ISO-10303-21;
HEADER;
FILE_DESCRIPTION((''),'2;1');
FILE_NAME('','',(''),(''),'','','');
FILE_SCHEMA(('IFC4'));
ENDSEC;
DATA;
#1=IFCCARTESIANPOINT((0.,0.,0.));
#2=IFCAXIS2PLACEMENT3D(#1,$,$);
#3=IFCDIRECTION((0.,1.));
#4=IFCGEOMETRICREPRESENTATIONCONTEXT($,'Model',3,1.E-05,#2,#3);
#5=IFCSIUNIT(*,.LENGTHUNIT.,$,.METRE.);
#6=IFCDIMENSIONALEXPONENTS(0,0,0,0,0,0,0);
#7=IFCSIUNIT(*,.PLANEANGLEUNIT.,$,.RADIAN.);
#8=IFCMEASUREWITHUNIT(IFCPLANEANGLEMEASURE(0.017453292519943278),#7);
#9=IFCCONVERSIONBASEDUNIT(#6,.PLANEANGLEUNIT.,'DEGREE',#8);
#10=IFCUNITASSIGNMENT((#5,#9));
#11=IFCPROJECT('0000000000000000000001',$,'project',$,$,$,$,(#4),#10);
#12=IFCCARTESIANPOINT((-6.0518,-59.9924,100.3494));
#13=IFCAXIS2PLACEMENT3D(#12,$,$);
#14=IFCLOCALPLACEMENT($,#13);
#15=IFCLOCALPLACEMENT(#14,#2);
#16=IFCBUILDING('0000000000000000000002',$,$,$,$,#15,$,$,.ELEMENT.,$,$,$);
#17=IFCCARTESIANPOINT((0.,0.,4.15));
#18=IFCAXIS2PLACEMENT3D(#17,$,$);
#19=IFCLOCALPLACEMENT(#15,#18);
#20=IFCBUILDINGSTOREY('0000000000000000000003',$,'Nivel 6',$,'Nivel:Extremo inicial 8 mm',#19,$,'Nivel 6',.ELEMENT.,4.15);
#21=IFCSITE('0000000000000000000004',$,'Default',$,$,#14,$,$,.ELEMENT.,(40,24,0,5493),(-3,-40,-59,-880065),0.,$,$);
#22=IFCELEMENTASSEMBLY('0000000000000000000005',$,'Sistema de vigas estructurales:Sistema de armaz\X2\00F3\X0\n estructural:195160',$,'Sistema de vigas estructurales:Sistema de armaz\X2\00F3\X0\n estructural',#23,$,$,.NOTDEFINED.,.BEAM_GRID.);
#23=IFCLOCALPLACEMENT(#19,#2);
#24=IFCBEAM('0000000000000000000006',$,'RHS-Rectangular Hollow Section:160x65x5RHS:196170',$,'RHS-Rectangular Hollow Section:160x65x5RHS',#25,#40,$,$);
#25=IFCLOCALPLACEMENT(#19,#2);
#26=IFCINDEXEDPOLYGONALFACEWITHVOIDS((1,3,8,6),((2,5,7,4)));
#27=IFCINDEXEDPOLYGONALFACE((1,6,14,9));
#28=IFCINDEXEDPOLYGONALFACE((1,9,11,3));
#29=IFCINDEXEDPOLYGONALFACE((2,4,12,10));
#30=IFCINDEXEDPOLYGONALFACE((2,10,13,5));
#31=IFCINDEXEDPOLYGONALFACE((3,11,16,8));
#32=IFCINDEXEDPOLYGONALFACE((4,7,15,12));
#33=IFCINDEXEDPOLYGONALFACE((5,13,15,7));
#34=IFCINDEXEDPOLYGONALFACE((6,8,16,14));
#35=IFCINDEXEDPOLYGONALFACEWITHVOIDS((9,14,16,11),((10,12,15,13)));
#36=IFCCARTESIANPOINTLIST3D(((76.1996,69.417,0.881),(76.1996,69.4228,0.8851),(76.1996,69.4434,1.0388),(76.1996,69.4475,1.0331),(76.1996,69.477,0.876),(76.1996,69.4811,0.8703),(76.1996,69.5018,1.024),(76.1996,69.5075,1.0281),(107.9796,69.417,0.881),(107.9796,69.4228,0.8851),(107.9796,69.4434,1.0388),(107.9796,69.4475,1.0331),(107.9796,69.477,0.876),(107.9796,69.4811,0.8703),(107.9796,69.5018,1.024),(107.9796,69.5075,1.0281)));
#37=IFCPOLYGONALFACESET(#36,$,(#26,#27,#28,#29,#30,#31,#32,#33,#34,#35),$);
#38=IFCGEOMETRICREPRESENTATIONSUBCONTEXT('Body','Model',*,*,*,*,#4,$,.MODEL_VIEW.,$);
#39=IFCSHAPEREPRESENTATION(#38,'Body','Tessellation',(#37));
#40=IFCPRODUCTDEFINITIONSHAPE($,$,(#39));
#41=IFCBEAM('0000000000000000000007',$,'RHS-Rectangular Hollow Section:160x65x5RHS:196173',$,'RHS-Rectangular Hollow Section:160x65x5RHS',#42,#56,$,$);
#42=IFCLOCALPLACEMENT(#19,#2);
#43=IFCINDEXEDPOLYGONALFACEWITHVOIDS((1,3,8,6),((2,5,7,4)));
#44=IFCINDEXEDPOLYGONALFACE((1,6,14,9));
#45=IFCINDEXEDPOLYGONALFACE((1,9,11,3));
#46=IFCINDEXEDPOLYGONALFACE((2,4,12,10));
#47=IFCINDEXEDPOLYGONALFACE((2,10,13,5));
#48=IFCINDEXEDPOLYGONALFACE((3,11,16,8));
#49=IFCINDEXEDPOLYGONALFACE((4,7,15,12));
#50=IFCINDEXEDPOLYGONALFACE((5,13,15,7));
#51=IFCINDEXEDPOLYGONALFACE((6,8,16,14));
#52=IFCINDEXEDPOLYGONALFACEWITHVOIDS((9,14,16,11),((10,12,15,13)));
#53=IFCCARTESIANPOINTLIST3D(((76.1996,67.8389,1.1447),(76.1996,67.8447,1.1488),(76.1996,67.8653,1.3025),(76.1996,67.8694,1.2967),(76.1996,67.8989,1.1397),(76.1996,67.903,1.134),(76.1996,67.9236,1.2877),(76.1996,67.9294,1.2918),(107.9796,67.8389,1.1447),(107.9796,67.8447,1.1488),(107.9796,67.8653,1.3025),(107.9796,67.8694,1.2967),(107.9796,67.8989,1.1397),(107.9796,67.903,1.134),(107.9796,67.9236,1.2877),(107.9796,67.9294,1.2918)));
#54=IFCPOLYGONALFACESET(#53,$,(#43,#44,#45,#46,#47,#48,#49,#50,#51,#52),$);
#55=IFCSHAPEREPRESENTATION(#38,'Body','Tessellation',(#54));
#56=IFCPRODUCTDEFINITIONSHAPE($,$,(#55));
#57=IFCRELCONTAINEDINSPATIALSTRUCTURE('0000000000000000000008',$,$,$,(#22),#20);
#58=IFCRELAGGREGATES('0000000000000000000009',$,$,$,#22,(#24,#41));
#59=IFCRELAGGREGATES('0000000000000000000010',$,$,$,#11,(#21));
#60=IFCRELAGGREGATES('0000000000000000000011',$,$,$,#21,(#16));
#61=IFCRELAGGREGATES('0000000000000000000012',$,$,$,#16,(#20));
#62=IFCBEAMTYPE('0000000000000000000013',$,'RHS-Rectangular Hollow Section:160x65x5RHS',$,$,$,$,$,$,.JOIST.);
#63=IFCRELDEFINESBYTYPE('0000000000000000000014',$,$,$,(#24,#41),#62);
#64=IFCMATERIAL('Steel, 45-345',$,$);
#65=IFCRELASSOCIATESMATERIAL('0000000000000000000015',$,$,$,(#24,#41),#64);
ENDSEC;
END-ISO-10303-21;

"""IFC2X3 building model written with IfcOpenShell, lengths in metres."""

from ifc_helpers import new_model, entity, si_unit, converted_unit, direction, frame, frame_2d, origin, place, context, subcontext, project, spatial, rectangle, extrude, boolean, material, type_object, element, aggregate, save


model = new_model("IFC2X3")

# Units and contexts
model_context = context("Model", 3, precision=1e-05, world=origin(), true_north=direction((0.0, 1.0)))
body_context = subcontext(model_context, "Body", "Model", "MODEL_VIEW")
ifc_project = project(units=[si_unit("LENGTHUNIT", "METRE"), converted_unit("PLANEANGLEUNIT", "DEGREE", entity("IfcPlaneAngleMeasure", 0.017453292519943278), si_unit("PLANEANGLEUNIT", "RADIAN"), dimensions=[0, 0, 0, 0, 0, 0, 0])], contexts=[model_context])

# Site, building, storey
site_placement = place(None, frame((-6.0518, -59.9924, 100.3494)))
site = spatial("IfcSite", under=ifc_project, at=site_placement, Name="Default", CompositionType="ELEMENT", RefLatitude=(40, 24, 0, 5493), RefLongitude=(-3, -40, -59, -880065), RefElevation=0.0)
building_placement = place(site_placement, origin())
building = spatial("IfcBuilding", under=site, at=building_placement, CompositionType="ELEMENT")
storey_placement = place(building_placement, frame((0.0, 0.0, 4.15)))
storey = spatial("IfcBuildingStorey", under=building, at=storey_placement, Name="Nivel 6", ObjectType="Nivel:Extremo inicial 8 mm", LongName="Nivel 6", CompositionType="ELEMENT", Elevation=4.15)

# Shared definitions
ifc_material_1 = material(Name="Steel, 45-345")

# Element assembly, beams
assembly_placement = place(storey_placement, origin())
assembly = element("IfcElementAssembly", 1, at=assembly_placement, inside=storey, Name="Sistema de vigas estructurales:Sistema de armazón estructural:195160", ObjectType="Sistema de vigas estructurales:Sistema de armazón estructural", AssemblyPlace="NOTDEFINED", PredefinedType="BEAM_GRID")
beam_type_1 = type_object("IfcBeamType", Name="RHS-Rectangular Hollow Section:160x65x5RHS", PredefinedType="JOIST")
beam_1_placement = place(assembly_placement, frame((107.9796, 69.4227, 0.7178), z_axis=(0.0, 0.0, 1.0), x_axis=(-1.0, 0.0, 0.0)))
beam_1 = element("IfcBeam", 2, at=beam_1_placement, type_object=beam_type_1, material=ifc_material_1, Name="RHS-Rectangular Hollow Section:160x65x5RHS:196170", ObjectType="RHS-Rectangular Hollow Section:160x65x5RHS", context=body_context, shape_type="SweptSolid", body=[
    boolean("DIFFERENCE", extrude(rectangle(XDim=0.16, YDim=0.065, at=frame_2d((0.0, 0.0), x_axis=(0.0, 1.0))), frame((0.0, -0.0396, 0.2367), z_axis=(1.0, 0.0, 0.0), x_axis=(0.0, -0.986325, -0.16481)), (0.0, 0.0, 1.0), 31.78), extrude(rectangle(XDim=0.15, YDim=0.055, at=frame_2d((0.0, 0.0), x_axis=(0.0, 1.0))), frame((31.78, -0.0396, 0.2367), z_axis=(-1.0, 0.0, 0.0), x_axis=(0.0, 0.986325, 0.16481)), (0.0, 0.0, 1.0), 31.78)),
])
beam_2_placement = place(assembly_placement, frame((107.9796, 67.8446, 0.9815), z_axis=(0.0, 0.0, 1.0), x_axis=(-1.0, 0.0, 0.0)))
beam_2 = element("IfcBeam", 3, at=beam_2_placement, type_object=beam_type_1, material=ifc_material_1, Name="RHS-Rectangular Hollow Section:160x65x5RHS:196173", ObjectType="RHS-Rectangular Hollow Section:160x65x5RHS", context=body_context, shape_type="SweptSolid", body=[
    boolean("DIFFERENCE", extrude(rectangle(XDim=0.16, YDim=0.065, at=frame_2d((0.0, 0.0), x_axis=(0.0, 1.0))), frame((0.0, -0.0396, 0.2367), z_axis=(1.0, 0.0, 0.0), x_axis=(0.0, -0.986325, -0.16481)), (0.0, 0.0, 1.0), 31.78), extrude(rectangle(XDim=0.15, YDim=0.055, at=frame_2d((0.0, 0.0), x_axis=(0.0, 1.0))), frame((31.78, -0.0396, 0.2367), z_axis=(-1.0, 0.0, 0.0), x_axis=(0.0, 0.986325, 0.16481)), (0.0, 0.0, 1.0), 31.78)),
])
aggregate(assembly, [beam_1, beam_2])

save(model, "model.ifc")
